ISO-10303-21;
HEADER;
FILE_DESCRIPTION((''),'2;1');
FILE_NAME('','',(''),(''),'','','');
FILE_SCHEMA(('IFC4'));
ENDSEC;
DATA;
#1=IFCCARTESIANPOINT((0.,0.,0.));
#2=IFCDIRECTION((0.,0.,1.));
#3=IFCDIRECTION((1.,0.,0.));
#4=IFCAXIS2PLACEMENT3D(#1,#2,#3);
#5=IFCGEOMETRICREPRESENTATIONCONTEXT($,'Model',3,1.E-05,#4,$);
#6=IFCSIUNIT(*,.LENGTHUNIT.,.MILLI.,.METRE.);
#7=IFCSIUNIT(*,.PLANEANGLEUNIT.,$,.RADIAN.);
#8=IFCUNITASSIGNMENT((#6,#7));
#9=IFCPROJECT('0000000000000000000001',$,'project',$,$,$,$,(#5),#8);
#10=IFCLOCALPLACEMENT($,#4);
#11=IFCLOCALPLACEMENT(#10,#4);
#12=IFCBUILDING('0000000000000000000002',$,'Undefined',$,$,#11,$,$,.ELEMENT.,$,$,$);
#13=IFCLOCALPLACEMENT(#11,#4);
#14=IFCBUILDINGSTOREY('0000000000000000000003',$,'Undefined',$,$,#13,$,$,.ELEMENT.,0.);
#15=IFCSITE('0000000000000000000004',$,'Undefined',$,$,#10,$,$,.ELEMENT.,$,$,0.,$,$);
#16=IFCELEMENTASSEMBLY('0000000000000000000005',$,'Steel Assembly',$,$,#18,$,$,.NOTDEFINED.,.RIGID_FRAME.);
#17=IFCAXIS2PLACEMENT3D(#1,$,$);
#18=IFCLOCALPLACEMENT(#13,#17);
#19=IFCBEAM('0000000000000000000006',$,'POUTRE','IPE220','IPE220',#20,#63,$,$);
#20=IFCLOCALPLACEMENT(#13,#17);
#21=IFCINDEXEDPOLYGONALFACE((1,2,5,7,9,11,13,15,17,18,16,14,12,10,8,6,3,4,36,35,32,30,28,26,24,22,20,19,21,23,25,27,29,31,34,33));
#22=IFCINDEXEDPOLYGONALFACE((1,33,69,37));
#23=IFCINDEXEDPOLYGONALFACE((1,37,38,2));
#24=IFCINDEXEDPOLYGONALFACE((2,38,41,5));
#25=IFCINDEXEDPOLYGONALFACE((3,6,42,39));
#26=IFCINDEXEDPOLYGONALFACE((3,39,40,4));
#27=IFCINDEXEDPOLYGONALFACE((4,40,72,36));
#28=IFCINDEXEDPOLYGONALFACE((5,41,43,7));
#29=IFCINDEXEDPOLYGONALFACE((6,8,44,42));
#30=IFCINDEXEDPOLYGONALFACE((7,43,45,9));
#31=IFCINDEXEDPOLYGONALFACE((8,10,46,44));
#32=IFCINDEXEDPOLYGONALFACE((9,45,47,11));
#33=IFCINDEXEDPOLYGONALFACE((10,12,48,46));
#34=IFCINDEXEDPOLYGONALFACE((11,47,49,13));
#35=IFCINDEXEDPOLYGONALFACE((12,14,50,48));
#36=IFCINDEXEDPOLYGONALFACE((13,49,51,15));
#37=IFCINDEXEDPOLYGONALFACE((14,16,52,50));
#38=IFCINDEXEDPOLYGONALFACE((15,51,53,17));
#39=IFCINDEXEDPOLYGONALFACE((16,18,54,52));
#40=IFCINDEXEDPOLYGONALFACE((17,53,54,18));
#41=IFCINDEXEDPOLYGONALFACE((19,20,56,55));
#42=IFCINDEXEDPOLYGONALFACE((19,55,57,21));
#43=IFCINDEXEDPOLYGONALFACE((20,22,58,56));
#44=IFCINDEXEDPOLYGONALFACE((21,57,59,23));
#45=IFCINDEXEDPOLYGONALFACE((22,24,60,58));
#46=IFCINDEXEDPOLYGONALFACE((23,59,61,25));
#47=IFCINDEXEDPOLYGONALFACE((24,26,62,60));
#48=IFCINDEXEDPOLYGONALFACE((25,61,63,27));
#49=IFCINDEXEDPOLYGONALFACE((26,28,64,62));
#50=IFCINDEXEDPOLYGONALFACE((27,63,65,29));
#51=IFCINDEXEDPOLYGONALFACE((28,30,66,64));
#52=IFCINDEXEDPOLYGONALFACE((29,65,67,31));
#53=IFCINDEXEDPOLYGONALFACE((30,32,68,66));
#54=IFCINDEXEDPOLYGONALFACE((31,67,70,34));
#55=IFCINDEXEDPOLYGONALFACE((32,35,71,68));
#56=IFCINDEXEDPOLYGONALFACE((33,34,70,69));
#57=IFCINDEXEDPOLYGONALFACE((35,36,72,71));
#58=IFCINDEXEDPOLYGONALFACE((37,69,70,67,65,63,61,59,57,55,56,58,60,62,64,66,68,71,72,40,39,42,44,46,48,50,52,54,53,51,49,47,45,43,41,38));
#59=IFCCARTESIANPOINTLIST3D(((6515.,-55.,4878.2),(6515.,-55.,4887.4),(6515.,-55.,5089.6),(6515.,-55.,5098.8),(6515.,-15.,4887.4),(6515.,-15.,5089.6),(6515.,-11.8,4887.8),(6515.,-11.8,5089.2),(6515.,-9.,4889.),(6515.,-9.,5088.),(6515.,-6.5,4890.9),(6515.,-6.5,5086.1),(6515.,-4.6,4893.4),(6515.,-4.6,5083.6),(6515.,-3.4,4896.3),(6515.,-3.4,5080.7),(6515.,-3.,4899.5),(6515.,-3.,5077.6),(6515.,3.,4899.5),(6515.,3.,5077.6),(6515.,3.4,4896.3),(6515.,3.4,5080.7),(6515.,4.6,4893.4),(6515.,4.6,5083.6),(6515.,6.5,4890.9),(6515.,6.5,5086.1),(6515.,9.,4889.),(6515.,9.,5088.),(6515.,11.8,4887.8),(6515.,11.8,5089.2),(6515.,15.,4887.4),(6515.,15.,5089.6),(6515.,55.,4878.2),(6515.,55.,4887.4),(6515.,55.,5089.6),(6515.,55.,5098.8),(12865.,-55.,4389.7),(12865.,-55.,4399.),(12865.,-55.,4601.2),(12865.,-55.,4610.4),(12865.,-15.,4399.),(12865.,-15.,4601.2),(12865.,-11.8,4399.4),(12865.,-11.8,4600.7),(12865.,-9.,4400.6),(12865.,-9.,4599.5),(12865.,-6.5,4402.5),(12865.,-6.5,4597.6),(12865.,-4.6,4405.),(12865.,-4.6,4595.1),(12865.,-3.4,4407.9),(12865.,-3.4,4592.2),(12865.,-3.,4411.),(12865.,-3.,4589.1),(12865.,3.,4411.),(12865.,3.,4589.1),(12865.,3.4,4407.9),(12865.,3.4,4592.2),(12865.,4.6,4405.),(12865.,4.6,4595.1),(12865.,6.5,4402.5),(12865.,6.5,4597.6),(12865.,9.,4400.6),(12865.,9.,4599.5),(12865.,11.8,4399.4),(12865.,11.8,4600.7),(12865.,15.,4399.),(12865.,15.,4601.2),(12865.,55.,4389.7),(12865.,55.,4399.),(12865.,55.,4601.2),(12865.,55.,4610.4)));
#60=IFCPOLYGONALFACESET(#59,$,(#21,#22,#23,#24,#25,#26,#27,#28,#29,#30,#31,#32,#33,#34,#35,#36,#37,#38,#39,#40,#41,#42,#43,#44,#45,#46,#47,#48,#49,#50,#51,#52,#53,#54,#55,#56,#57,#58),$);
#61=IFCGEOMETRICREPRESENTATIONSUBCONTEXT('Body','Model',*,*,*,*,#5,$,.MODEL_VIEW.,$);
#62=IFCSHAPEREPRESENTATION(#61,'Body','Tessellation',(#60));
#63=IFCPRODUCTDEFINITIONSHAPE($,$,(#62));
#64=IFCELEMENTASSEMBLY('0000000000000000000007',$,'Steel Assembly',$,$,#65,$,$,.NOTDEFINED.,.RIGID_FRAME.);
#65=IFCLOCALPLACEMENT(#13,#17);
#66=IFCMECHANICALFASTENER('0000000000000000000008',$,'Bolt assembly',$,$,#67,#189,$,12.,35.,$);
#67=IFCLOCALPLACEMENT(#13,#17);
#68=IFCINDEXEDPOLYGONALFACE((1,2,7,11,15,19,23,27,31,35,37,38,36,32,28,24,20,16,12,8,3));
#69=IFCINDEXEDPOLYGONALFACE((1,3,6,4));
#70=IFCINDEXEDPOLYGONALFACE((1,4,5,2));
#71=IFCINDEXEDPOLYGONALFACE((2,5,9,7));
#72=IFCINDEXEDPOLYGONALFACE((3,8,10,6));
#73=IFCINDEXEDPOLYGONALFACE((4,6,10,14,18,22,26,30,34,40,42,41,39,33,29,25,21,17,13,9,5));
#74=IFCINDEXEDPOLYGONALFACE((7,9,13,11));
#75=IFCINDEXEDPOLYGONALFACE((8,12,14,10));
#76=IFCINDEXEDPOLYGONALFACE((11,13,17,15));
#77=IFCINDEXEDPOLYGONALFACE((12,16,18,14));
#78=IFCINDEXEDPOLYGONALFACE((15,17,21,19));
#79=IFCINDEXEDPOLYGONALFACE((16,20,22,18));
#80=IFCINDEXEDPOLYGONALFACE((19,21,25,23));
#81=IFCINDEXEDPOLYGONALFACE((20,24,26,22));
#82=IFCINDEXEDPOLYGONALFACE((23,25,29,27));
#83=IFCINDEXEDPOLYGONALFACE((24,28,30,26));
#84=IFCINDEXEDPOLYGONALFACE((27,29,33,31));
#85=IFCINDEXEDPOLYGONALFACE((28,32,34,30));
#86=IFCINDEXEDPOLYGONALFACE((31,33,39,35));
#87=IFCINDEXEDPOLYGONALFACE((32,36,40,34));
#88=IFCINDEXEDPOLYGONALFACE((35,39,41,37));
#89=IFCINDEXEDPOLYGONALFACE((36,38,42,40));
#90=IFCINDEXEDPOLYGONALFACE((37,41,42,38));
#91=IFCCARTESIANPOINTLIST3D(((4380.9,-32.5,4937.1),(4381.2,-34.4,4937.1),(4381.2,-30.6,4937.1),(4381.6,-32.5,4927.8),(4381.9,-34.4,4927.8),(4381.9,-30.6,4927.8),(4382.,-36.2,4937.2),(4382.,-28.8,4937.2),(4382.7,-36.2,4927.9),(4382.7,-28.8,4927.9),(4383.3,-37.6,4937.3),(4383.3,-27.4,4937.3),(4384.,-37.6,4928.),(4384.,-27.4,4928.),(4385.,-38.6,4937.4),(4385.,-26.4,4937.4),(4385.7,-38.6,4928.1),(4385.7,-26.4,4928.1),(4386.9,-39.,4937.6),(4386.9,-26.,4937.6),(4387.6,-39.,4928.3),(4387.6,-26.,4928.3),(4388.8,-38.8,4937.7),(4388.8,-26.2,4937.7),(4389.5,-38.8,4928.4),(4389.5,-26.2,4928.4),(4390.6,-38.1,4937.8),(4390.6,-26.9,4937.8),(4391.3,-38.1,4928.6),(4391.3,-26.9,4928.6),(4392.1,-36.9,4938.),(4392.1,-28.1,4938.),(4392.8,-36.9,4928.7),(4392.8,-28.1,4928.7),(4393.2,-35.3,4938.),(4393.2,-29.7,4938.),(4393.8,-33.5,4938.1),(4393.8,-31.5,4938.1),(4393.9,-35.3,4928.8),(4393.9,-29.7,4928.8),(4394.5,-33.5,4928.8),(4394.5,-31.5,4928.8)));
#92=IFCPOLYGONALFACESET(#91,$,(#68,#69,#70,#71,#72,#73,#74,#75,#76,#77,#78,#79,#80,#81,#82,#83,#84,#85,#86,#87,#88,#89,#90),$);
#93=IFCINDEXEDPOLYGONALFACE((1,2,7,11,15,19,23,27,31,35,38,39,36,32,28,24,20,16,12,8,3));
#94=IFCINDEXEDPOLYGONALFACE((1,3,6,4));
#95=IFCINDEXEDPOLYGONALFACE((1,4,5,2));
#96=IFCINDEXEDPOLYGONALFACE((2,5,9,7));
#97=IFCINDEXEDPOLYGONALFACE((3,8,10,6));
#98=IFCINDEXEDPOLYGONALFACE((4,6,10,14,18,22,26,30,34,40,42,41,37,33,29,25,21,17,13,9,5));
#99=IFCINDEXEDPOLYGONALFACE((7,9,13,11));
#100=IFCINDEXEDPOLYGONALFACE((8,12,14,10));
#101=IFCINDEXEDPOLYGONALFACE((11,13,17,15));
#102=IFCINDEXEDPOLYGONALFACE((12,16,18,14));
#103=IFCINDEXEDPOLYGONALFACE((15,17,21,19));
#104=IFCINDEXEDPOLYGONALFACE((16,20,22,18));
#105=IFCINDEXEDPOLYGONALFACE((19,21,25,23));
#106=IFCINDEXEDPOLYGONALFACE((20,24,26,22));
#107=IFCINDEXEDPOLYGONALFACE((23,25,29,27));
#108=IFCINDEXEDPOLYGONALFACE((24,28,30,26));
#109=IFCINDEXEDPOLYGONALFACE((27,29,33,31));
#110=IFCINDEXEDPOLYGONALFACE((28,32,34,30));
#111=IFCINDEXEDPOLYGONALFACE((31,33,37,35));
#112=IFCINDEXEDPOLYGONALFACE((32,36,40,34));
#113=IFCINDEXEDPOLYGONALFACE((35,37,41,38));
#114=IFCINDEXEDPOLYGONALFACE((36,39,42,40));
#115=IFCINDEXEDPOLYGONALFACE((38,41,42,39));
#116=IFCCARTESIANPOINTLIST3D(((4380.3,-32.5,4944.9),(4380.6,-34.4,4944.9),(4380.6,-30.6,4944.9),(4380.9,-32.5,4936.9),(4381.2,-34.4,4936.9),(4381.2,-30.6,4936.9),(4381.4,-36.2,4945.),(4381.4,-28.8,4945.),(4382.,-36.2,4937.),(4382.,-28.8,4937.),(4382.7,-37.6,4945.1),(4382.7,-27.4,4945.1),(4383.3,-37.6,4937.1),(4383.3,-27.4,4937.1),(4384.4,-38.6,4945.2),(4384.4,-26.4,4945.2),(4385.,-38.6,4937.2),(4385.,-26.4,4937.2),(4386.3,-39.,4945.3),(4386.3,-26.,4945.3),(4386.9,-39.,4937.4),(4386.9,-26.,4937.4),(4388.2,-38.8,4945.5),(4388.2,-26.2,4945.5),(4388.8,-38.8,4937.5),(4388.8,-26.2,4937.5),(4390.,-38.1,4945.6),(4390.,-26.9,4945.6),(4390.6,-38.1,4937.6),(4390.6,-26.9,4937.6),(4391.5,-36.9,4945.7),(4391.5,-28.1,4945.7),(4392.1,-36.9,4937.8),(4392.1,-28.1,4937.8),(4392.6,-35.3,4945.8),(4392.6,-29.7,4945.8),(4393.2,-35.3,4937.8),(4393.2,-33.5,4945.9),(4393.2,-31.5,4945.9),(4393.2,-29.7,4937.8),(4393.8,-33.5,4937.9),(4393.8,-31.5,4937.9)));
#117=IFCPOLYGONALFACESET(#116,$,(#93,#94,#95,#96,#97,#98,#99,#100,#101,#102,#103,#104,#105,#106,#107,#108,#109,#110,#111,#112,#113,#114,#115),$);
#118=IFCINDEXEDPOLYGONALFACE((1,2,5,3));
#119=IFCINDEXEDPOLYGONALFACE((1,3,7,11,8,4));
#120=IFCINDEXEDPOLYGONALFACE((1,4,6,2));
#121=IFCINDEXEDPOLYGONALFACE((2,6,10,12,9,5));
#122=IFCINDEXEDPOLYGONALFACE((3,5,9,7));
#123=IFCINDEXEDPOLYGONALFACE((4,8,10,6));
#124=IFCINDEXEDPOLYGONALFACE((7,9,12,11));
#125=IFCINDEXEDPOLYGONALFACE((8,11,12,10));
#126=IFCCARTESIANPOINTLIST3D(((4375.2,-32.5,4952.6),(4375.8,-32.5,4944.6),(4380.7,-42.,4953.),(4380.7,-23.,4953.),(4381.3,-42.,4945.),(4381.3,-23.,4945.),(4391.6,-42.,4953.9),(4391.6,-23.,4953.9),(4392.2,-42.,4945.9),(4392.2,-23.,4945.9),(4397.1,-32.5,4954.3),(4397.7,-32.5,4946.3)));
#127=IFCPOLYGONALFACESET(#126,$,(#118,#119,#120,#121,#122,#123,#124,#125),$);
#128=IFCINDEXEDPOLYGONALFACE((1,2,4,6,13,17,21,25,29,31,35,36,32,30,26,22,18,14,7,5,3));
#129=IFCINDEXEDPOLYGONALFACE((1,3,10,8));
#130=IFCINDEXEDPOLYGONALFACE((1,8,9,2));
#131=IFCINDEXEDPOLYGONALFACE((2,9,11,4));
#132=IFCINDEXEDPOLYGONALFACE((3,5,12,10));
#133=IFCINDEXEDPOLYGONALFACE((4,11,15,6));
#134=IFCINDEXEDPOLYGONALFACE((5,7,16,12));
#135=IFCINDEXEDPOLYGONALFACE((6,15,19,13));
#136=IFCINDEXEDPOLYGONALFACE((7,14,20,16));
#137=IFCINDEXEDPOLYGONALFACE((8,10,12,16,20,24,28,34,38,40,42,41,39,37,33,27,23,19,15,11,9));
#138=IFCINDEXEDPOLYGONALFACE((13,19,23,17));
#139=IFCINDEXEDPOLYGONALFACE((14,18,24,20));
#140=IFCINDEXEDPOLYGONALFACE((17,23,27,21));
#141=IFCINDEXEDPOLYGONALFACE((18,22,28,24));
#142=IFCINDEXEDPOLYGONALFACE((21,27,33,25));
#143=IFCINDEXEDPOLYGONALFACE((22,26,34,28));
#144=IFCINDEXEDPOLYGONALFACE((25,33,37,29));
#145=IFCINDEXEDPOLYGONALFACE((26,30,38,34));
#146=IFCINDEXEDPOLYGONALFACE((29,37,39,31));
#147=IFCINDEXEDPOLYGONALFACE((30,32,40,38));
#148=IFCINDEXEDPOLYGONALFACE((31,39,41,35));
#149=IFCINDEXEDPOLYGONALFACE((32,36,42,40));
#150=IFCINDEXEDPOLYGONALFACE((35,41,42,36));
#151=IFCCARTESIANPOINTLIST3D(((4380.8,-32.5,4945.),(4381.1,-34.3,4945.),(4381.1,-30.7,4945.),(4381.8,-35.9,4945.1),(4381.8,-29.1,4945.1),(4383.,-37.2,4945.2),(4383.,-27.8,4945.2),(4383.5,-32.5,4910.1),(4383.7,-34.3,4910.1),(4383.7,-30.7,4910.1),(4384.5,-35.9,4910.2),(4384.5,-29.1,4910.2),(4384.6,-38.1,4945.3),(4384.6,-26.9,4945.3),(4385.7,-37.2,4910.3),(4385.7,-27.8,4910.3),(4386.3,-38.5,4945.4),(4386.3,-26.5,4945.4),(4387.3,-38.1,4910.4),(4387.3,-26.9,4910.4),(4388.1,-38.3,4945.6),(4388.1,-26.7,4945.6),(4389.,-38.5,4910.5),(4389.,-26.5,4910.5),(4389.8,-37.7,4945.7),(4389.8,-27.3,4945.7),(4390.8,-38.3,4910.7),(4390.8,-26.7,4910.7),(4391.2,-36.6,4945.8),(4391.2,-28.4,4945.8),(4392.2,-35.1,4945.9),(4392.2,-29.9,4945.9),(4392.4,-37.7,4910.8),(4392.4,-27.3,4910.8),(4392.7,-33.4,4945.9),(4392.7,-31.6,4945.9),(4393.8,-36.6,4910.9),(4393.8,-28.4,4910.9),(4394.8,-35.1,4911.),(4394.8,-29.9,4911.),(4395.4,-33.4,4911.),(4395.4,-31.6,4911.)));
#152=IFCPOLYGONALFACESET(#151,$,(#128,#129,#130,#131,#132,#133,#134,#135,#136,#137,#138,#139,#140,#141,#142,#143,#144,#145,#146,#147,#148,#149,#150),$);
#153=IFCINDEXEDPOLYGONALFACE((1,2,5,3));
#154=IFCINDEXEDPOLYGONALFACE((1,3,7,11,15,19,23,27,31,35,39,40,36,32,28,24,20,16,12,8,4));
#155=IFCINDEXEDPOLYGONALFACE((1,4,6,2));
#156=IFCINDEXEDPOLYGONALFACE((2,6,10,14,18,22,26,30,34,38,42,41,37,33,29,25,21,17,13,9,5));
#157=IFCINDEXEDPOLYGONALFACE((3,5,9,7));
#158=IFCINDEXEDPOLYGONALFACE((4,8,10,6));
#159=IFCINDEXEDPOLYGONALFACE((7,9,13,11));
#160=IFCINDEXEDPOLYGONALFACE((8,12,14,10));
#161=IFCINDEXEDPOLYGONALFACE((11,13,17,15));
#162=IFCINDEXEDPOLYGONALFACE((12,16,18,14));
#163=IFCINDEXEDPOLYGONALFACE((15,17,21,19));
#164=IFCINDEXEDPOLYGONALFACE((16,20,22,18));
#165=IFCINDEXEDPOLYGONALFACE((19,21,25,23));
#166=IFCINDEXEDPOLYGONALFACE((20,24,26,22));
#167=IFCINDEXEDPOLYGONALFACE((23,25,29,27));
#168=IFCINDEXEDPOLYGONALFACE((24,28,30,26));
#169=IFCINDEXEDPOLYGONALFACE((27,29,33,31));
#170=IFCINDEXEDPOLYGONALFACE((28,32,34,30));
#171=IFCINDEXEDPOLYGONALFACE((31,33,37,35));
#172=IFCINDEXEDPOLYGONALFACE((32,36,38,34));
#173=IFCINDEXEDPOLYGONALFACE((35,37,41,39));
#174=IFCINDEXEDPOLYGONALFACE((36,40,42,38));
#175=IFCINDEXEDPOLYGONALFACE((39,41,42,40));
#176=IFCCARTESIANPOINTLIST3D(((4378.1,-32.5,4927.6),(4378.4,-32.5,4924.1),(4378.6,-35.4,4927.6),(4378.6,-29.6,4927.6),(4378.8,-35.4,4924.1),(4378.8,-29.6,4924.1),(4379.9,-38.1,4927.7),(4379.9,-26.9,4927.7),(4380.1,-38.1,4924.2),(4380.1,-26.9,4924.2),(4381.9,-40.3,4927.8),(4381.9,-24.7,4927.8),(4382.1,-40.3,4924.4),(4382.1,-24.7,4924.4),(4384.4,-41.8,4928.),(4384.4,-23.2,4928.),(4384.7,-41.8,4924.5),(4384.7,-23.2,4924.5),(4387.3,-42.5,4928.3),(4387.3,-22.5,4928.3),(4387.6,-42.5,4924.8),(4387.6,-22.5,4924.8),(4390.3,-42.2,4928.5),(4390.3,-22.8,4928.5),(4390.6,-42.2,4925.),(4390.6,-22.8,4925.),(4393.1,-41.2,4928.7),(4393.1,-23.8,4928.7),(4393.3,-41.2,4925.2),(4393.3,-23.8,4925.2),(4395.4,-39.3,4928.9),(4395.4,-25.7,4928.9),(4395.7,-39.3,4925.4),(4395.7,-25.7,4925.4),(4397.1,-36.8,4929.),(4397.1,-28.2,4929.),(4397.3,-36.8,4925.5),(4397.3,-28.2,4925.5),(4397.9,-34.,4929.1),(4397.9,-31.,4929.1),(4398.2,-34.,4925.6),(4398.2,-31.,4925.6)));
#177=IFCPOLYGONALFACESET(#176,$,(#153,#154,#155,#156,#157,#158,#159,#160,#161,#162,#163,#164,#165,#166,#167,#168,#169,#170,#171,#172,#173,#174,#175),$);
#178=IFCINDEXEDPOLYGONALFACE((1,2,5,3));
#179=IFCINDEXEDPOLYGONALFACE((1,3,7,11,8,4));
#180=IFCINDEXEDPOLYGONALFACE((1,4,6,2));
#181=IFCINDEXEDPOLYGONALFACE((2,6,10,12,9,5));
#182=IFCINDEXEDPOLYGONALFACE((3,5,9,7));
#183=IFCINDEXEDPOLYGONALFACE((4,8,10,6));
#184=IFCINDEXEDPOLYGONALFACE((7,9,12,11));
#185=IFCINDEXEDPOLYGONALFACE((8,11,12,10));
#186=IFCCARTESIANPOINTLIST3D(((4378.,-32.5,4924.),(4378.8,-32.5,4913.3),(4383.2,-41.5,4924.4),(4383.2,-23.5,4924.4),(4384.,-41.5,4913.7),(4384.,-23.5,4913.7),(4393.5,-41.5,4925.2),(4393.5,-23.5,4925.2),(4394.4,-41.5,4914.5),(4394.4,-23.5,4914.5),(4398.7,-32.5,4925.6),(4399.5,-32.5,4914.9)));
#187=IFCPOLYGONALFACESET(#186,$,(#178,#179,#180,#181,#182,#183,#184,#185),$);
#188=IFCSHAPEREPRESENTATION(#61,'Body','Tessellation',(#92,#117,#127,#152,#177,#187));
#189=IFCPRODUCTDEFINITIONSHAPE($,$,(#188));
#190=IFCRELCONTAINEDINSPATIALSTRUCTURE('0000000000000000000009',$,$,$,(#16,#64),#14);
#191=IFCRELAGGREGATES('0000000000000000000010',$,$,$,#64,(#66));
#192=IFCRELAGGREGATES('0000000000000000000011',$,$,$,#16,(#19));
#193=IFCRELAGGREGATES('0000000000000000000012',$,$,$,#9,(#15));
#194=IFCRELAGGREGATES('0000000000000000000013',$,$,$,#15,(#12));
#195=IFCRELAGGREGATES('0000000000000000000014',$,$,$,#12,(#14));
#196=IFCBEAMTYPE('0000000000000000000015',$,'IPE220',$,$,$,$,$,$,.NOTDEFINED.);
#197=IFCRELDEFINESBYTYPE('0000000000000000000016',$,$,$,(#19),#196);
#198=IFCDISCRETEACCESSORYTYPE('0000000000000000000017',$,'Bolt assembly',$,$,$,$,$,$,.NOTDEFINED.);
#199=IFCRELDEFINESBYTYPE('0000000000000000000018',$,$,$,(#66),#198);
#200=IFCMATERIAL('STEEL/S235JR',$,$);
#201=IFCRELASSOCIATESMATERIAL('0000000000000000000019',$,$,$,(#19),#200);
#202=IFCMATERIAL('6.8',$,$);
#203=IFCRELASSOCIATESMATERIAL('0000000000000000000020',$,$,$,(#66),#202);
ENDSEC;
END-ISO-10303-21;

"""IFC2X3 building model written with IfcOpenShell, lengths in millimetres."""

from ifc_helpers import new_model, si_unit, frame, origin_with_axes, origin_2d_with_axis, place, context, subcontext, project, spatial, polyline, circle, i_section, outline, extrude, clip, halfspace, source, transform, mapped, material, type_object, element, aggregate, save


model = new_model("IFC2X3")

# Units and contexts
model_context = context("Model", 3, precision=1e-05, world=origin_with_axes())
body_context = subcontext(model_context, "Body", "Model", "MODEL_VIEW")
ifc_project = project(units=[si_unit("LENGTHUNIT", "METRE", prefix="MILLI"), si_unit("PLANEANGLEUNIT", "RADIAN")], contexts=[model_context])

# Site, building, storey
site_placement = place(None, origin_with_axes())
site = spatial("IfcSite", under=ifc_project, at=site_placement, Name="Undefined", CompositionType="ELEMENT", RefElevation=0.0)
building_placement = place(site_placement, origin_with_axes())
building = spatial("IfcBuilding", under=site, at=building_placement, Name="Undefined", CompositionType="ELEMENT")
storey_placement = place(building_placement, origin_with_axes())
storey = spatial("IfcBuildingStorey", under=building, at=storey_placement, Name="Undefined", CompositionType="ELEMENT", Elevation=0.0)

# Element assembly, beam
ifc_material_1 = material(Name="STEEL/S235JR")
assembly_1_placement = place(storey_placement, origin_with_axes())
assembly_1 = element("IfcElementAssembly", 1, at=assembly_1_placement, inside=storey, Name="Steel Assembly", AssemblyPlace="NOTDEFINED", PredefinedType="RIGID_FRAME")
beam_type_1 = type_object("IfcBeamType", Name="IPE220", PredefinedType="NOTDEFINED")
beam_1_placement = place(assembly_1_placement, frame((6491.6, 0.0, 4990.3), z_axis=(0.076696, 0.0, 0.997054), x_axis=(0.997054, 0.0, -0.076696)))
beam_1 = element("IfcBeam", 2, at=beam_1_placement, type_object=beam_type_1, material=ifc_material_1, Name="POUTRE", Description="IPE220", ObjectType="IPE220", context=body_context, shape_type="Clipping", body=[
    clip(clip(extrude(i_section(OverallWidth=110.0, OverallDepth=220.0, WebThickness=5.9, FlangeThickness=9.2, FilletRadius=12.0, at=origin_2d_with_axis()), frame((6409.4, 0.0, 0.0), z_axis=(-1.0, 0.0, 0.0), x_axis=(0.0, -1.0, 0.0)), (0.0, 0.0, 1.0), 6402.9), halfspace(frame((6400.7, 0.0, -110.0), z_axis=(-0.997054, 0.0, -0.076696), x_axis=(-0.076696, 0.0, 0.997054)), True)), halfspace(frame((15.0, 0.0, 111.2), z_axis=(-0.997054, 0.0, -0.076696), x_axis=(0.0, -1.0, 0.0)), False)),
])

# Element assembly, mechanical fastener
assembly_2_placement = place(storey_placement, origin_with_axes())
assembly_2 = element("IfcElementAssembly", 3, at=assembly_2_placement, inside=storey, Name="Steel Assembly", AssemblyPlace="NOTDEFINED", PredefinedType="RIGID_FRAME")
ifc_material_2 = material(Name="6.8")
discrete_accessory_type_1 = type_object("IfcDiscreteAccessoryType", Name="Bolt assembly")
shared_shape_1 = source(origin_with_axes(), body_context, "Body", "SweptSolid", [
    extrude(circle(Radius=6.5, at=origin_2d_with_axis()), frame((0.0, -0.1, 0.0), z_axis=(0.0, 1.0, 0.0), x_axis=(1.0, 0.0, 0.0)), (0.0, 0.0, 1.0), 9.3),
    extrude(circle(Radius=6.5, at=origin_2d_with_axis()), frame((0.0, -7.9, 0.0), z_axis=(0.0, 1.0, 0.0), x_axis=(1.0, 0.0, 0.0)), (0.0, 0.0, 1.0), 8.0),
    extrude(outline(polyline([(11.0, 0.0), (5.5, 9.5), (-5.5, 9.5), (-11.0, 0.0), (-5.5, -9.5), (5.5, -9.5), (11.0, 0.0)])), frame((0.0, -16.0, 0.0), z_axis=(0.0, 1.0, 0.0), x_axis=(1.0, 0.0, 0.0)), (0.0, 0.0, 1.0), 8.0),
    extrude(circle(Radius=6.0, at=origin_2d_with_axis()), frame((0.0, -8.0, 0.0), z_axis=(0.0, 1.0, 0.0), x_axis=(1.0, 0.0, 0.0)), (0.0, 0.0, 1.0), 35.0),
    extrude(circle(Radius=10.0, at=origin_2d_with_axis()), frame((0.0, 9.2, 0.0), z_axis=(0.0, 1.0, 0.0), x_axis=(1.0, 0.0, 0.0)), (0.0, 0.0, 1.0), 3.5),
    extrude(outline(polyline([(10.4, 0.0), (5.2, 9.0), (-5.2, 9.0), (-10.4, 0.0), (-5.2, -9.0), (5.2, -9.0), (10.4, 0.0)])), frame((0.0, 12.7, 0.0), z_axis=(0.0, 1.0, 0.0), x_axis=(1.0, 0.0, 0.0)), (0.0, 0.0, 1.0), 10.8),
])
mechanical_fastener_1_placement = place(assembly_2_placement, frame((4387.4, -32.5, 4937.5), z_axis=(0.0, -1.0, 0.0), x_axis=(-0.997054, 0.0, -0.076696)))
mechanical_fastener_1 = element("IfcMechanicalFastener", 4, at=mechanical_fastener_1_placement, type_object=discrete_accessory_type_1, material=ifc_material_2, Name="Bolt assembly", NominalDiameter=12.0, NominalLength=35.0, context=body_context, shape_type="MappedRepresentation", body=[
    mapped(shared_shape_1, transform((0.0, 0.0, 0.0))),
])
aggregate(assembly_2, [mechanical_fastener_1])

aggregate(assembly_1, [beam_1])

save(model, "model.ifc")
